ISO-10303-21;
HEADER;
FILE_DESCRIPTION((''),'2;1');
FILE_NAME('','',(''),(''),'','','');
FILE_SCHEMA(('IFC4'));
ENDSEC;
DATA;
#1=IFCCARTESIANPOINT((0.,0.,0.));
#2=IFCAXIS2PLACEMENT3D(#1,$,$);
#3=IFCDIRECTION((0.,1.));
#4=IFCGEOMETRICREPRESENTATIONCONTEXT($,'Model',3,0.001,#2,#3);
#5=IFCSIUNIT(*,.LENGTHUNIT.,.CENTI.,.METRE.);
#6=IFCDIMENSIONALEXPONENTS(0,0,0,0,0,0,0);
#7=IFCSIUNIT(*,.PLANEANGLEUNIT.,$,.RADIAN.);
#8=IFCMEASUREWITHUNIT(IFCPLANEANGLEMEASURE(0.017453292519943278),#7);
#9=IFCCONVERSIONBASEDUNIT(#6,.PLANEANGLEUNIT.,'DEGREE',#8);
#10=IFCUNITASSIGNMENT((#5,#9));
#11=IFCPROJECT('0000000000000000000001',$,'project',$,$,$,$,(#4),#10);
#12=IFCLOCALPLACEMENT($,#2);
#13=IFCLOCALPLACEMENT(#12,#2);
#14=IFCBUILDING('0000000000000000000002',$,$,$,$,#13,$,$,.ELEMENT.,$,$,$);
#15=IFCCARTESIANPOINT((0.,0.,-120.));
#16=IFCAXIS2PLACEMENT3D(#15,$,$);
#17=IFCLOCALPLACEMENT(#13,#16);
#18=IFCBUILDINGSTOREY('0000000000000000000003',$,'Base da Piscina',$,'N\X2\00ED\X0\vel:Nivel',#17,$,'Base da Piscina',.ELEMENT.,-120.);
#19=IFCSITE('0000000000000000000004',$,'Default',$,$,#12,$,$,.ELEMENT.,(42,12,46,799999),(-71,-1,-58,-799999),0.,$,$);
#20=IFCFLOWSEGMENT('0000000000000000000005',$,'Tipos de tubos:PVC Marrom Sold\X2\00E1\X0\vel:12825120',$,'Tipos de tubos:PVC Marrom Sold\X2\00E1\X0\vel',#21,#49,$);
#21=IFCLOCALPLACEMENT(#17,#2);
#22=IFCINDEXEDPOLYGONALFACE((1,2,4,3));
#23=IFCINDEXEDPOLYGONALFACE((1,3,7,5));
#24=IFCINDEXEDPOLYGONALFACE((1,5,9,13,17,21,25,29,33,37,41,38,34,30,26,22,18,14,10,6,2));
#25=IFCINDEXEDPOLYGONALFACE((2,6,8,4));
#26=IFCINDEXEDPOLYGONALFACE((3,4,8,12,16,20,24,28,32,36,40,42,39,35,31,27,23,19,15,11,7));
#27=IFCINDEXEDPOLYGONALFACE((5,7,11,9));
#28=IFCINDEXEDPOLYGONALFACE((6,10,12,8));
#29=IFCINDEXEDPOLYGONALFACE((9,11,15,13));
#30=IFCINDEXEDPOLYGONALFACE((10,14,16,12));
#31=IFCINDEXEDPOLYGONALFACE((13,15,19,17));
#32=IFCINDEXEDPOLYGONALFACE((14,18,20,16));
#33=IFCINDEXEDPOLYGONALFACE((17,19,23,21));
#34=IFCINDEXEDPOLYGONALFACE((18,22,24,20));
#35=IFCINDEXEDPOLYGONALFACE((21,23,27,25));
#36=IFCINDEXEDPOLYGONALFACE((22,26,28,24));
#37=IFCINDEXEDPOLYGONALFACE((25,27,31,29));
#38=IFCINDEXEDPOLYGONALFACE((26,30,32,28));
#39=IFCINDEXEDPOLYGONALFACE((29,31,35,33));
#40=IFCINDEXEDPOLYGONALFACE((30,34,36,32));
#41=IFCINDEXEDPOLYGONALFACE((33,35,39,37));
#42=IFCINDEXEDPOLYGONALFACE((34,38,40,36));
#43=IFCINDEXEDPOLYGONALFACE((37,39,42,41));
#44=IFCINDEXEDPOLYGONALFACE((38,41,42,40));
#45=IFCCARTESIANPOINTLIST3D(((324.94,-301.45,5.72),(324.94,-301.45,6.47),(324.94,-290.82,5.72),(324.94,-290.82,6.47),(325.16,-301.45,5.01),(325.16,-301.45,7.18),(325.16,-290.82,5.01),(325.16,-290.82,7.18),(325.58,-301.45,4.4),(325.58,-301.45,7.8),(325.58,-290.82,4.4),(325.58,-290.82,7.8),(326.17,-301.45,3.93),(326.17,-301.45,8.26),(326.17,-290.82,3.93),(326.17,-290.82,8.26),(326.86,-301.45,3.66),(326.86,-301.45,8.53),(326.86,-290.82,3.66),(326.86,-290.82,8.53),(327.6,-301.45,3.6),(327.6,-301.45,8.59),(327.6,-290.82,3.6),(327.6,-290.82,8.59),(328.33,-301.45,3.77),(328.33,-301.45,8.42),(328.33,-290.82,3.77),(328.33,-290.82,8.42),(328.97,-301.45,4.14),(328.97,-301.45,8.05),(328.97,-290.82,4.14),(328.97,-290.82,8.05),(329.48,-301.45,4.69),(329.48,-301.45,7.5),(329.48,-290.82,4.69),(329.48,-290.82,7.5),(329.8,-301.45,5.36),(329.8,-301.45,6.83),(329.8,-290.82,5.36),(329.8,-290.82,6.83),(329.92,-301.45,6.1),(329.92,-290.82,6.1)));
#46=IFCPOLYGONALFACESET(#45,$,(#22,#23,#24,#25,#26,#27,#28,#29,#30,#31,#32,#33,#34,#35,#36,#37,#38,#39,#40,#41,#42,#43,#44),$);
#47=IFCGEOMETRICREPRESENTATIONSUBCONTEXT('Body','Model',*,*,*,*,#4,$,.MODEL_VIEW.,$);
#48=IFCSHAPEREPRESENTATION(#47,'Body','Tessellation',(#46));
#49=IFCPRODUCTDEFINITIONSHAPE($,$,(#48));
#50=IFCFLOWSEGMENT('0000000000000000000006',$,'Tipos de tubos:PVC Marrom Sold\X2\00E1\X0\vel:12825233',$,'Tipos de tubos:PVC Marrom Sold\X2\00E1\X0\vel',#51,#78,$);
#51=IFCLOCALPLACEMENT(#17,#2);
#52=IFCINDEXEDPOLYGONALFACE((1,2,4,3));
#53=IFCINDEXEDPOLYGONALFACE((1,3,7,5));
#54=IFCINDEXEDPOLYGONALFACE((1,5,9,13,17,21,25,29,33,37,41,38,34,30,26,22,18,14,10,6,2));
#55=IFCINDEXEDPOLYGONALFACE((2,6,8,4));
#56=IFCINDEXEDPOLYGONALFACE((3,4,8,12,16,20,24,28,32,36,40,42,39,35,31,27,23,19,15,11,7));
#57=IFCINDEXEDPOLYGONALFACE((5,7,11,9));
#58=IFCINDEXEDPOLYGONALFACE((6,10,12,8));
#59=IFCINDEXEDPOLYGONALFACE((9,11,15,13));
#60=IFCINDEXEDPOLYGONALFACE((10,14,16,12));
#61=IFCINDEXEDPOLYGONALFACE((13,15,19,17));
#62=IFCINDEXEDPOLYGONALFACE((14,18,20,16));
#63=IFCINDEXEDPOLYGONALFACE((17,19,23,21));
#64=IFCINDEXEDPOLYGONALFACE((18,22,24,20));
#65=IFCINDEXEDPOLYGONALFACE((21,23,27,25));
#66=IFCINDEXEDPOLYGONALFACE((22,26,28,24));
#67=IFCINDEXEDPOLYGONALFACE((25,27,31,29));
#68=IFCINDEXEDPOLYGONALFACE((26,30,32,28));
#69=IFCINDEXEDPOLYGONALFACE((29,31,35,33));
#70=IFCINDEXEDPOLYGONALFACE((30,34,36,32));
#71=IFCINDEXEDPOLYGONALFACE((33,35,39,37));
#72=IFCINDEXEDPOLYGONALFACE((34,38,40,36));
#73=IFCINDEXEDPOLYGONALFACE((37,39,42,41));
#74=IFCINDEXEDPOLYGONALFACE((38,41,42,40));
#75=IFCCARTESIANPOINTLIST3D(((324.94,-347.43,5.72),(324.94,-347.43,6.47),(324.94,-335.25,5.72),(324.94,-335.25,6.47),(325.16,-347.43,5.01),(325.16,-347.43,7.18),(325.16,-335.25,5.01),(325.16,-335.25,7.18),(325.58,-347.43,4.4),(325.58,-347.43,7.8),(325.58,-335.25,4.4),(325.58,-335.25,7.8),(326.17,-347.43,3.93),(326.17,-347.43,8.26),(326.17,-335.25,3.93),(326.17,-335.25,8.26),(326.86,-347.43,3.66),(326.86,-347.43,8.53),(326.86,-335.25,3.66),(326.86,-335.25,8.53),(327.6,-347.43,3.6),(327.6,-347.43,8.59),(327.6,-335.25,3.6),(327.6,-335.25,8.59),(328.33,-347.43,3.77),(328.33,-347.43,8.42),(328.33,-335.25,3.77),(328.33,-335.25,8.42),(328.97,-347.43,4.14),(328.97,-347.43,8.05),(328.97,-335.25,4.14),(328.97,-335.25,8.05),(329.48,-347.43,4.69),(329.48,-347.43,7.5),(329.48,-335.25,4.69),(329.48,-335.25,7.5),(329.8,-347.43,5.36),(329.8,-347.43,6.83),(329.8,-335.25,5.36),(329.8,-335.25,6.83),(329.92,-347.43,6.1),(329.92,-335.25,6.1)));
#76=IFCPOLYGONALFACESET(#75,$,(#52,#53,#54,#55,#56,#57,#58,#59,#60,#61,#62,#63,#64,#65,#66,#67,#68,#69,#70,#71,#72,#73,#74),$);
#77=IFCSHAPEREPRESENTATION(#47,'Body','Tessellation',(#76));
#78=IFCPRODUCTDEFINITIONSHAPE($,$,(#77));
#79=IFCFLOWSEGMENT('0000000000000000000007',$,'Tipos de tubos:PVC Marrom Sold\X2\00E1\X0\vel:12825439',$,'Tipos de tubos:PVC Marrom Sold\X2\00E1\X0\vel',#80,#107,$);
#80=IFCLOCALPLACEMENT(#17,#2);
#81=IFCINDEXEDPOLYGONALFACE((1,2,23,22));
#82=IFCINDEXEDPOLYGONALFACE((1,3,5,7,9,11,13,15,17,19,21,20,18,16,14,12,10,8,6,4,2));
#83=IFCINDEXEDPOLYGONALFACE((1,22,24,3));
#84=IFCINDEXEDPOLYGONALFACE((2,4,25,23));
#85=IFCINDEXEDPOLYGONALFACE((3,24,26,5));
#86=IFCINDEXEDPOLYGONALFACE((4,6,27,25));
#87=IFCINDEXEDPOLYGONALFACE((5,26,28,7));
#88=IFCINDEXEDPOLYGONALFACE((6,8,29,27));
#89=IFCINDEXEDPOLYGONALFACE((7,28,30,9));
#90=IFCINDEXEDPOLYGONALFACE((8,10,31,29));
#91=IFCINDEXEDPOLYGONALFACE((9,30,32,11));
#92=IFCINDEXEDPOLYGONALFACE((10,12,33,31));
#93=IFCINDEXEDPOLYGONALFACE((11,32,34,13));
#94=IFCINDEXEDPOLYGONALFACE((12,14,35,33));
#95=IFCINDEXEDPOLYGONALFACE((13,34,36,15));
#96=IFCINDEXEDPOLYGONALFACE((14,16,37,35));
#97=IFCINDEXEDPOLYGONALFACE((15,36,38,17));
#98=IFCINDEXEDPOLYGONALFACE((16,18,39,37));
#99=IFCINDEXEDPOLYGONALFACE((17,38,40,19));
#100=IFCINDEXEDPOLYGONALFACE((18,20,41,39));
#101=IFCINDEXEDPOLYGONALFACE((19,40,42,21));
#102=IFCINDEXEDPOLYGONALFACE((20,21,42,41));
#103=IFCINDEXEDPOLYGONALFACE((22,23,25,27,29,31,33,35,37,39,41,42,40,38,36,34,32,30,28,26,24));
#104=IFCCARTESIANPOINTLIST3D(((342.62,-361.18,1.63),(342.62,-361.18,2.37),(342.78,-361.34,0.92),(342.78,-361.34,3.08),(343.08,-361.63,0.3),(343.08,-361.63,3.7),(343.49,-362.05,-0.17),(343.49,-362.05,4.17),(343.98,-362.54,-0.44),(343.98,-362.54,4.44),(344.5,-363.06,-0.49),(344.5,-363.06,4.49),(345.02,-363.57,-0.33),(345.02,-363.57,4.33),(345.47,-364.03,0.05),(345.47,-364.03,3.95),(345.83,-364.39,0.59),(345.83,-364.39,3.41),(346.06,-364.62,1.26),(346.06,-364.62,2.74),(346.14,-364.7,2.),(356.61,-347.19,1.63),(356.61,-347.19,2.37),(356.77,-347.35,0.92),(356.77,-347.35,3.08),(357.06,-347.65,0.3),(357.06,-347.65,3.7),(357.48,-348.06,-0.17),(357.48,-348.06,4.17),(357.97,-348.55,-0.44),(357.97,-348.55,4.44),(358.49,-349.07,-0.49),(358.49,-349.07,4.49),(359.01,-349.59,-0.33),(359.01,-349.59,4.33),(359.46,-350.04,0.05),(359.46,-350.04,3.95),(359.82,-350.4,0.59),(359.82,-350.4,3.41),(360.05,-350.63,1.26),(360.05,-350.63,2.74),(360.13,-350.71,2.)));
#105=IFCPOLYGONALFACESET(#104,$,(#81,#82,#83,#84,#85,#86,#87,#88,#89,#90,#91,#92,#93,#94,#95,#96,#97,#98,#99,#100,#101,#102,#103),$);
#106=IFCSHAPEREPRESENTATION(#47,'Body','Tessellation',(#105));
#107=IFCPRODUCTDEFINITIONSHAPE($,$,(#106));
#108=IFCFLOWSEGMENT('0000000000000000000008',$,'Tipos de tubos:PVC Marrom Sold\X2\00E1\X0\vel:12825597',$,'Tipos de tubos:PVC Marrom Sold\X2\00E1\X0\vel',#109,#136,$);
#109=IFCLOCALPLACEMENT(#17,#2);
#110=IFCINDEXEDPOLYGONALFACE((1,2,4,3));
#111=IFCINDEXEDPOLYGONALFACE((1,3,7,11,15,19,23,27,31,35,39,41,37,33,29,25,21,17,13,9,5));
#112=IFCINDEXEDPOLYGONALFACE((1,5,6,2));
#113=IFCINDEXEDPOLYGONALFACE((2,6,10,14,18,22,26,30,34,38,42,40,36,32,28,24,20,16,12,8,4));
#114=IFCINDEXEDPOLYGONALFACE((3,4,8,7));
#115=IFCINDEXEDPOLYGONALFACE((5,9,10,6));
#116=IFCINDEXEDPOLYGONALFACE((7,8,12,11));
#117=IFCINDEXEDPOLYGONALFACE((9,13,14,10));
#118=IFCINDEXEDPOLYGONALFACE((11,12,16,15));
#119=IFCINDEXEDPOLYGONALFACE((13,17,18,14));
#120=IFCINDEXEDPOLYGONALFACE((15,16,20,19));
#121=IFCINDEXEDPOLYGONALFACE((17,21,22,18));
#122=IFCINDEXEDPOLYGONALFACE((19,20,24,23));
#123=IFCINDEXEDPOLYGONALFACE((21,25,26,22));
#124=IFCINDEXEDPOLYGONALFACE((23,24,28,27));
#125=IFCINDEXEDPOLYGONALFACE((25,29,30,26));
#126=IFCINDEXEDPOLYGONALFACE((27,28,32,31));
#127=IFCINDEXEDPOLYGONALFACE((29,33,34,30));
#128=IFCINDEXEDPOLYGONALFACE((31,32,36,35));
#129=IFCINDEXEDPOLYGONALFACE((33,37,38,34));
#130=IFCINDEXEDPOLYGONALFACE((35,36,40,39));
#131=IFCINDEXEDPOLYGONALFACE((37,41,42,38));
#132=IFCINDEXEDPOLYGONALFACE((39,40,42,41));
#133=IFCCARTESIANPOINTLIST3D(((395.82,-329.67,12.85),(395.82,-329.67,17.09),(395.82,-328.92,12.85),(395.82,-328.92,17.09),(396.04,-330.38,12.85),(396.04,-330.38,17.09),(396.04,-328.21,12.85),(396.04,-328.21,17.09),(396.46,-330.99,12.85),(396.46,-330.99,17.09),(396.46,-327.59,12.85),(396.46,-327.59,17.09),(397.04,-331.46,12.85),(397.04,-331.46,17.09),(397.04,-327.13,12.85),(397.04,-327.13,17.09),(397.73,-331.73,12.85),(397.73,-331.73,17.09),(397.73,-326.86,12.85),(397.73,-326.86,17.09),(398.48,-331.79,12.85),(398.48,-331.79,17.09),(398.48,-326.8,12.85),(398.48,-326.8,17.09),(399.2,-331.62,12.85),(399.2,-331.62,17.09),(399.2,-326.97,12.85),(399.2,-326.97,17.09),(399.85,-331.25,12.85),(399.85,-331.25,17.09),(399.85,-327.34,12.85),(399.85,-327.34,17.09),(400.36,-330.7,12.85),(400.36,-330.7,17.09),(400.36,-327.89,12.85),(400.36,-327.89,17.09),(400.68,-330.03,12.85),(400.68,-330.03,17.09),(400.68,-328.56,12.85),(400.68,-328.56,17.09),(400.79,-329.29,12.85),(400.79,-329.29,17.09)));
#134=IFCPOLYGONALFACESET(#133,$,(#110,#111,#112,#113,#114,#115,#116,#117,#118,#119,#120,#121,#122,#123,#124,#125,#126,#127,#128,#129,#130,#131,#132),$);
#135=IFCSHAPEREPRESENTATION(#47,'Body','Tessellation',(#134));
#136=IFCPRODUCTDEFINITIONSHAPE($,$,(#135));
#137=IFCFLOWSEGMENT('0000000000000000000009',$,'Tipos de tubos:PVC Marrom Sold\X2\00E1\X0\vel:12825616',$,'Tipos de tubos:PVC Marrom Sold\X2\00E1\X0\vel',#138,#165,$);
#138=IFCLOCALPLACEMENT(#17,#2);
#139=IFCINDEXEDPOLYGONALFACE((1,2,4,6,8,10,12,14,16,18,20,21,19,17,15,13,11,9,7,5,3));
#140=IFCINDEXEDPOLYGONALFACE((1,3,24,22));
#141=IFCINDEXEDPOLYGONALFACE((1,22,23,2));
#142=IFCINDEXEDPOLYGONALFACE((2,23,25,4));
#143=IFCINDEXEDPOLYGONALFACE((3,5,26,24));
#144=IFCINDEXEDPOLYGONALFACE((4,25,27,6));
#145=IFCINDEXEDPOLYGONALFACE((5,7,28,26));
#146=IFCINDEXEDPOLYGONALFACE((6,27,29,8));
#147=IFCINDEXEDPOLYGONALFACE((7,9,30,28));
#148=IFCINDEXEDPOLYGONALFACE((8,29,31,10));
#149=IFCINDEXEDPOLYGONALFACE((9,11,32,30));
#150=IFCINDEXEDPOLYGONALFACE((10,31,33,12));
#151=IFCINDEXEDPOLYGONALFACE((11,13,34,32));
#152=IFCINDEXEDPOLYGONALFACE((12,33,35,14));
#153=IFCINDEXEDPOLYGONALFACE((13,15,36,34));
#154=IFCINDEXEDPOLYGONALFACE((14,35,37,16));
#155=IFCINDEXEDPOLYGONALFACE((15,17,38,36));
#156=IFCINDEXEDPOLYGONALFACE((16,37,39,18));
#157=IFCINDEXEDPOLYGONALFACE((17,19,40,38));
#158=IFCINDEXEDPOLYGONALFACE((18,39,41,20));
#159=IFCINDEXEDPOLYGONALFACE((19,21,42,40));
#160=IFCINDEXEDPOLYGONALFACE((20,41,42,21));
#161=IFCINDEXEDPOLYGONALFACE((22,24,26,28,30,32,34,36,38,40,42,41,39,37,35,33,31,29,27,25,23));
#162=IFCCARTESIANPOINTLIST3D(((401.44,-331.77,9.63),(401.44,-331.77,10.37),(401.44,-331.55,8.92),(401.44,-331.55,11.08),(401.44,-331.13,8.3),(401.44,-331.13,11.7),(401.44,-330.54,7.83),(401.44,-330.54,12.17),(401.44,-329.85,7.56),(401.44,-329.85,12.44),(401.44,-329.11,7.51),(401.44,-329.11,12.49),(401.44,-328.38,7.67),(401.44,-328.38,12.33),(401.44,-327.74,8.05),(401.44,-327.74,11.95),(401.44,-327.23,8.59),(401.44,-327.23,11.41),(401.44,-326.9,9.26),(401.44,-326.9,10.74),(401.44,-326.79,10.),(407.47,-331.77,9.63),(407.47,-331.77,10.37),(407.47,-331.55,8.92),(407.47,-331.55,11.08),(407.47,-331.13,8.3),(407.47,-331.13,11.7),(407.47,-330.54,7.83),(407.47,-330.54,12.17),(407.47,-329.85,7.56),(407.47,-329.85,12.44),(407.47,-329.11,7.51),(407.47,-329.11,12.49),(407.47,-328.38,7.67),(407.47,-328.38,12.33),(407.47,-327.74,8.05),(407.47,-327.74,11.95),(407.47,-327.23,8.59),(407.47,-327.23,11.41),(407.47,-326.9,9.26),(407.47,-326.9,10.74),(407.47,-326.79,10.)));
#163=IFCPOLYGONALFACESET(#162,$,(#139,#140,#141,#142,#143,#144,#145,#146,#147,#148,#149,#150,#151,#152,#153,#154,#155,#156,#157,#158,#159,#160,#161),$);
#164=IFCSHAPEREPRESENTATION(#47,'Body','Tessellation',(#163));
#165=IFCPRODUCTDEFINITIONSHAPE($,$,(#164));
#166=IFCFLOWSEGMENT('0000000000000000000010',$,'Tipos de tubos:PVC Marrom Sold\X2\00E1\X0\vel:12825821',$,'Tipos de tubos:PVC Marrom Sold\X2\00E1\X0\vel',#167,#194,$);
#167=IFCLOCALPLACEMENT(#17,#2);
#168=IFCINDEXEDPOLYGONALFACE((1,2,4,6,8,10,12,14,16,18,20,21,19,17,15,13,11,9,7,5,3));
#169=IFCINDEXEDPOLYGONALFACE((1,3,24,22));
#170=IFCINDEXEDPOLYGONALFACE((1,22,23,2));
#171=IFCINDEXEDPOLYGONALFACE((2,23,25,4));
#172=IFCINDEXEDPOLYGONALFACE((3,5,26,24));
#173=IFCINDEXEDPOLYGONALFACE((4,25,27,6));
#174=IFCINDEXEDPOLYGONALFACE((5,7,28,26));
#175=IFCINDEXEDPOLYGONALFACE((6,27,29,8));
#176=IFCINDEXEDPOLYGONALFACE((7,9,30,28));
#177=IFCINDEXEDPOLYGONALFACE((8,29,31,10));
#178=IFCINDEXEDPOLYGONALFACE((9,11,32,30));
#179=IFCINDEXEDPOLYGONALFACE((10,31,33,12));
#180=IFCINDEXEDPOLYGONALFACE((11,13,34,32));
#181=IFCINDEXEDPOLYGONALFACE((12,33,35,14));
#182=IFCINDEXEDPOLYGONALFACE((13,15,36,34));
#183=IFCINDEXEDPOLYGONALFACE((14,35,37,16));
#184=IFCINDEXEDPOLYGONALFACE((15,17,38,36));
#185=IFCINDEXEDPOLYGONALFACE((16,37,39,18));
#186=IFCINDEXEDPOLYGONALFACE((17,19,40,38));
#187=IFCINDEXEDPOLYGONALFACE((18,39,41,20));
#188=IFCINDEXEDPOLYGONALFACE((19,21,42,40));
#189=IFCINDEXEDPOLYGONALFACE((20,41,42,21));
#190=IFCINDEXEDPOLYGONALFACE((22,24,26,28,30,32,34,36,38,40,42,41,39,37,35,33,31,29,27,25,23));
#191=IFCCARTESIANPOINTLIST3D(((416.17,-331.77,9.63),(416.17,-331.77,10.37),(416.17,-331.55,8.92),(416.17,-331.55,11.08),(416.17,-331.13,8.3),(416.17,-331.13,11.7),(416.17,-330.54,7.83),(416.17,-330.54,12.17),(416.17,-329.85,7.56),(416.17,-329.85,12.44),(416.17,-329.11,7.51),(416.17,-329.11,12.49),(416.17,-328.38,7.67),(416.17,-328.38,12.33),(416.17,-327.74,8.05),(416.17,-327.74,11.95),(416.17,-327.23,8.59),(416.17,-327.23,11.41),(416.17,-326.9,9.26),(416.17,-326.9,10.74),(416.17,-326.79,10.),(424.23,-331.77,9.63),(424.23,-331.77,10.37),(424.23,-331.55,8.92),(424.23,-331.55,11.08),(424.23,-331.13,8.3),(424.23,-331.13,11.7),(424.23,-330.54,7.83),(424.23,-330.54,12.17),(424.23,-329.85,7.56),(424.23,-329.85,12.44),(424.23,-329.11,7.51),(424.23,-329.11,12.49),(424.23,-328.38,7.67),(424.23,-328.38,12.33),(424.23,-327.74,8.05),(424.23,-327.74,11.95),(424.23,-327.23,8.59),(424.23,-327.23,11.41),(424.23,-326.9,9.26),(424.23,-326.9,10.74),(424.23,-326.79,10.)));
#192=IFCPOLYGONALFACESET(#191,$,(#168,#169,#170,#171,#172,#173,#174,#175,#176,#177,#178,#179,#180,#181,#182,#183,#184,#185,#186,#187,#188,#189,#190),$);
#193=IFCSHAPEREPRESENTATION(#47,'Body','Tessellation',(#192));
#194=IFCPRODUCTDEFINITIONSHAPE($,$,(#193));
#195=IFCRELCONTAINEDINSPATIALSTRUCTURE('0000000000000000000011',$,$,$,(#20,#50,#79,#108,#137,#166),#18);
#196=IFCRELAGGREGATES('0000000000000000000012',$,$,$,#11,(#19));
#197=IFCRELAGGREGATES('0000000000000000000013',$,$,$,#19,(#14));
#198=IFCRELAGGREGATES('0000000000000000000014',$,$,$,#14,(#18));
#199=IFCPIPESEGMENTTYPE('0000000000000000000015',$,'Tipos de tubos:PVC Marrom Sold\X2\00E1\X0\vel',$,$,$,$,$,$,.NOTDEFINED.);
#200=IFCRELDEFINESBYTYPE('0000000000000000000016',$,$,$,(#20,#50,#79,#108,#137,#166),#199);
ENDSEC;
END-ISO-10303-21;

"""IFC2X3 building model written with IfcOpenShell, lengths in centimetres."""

from ifc_helpers import new_model, entity, si_unit, converted_unit, direction, frame, origin, origin_2d_with_axis, place, context, subcontext, project, spatial, circle, extrude, type_object, element, save


model = new_model("IFC2X3")

# Units and contexts
model_context = context("Model", 3, precision=0.001, world=origin(), true_north=direction((0.0, 1.0)))
body_context = subcontext(model_context, "Body", "Model", "MODEL_VIEW")
ifc_project = project(units=[si_unit("LENGTHUNIT", "METRE", prefix="CENTI"), converted_unit("PLANEANGLEUNIT", "DEGREE", entity("IfcPlaneAngleMeasure", 0.017453292519943278), si_unit("PLANEANGLEUNIT", "RADIAN"), dimensions=[0, 0, 0, 0, 0, 0, 0])], contexts=[model_context])

# Site, building, storey
site_placement = place(None, origin())
site = spatial("IfcSite", under=ifc_project, at=site_placement, Name="Default", CompositionType="ELEMENT", RefLatitude=(42, 12, 46, 799999), RefLongitude=(-71, -1, -58, -799999), RefElevation=0.0)
building_placement = place(site_placement, origin())
building = spatial("IfcBuilding", under=site, at=building_placement, CompositionType="ELEMENT")
storey_placement = place(building_placement, frame((0.0, 0.0, -120.0)))
storey = spatial("IfcBuildingStorey", under=building, at=storey_placement, Name="Base da Piscina", ObjectType="Nível:Nivel", LongName="Base da Piscina", CompositionType="ELEMENT", Elevation=-120.0)

# Flow segments
pipe_segment_type = type_object("IfcPipeSegmentType", Name="Tipos de tubos:PVC Marrom Soldável", PredefinedType="NOTDEFINED")
flow_segment_1_placement = place(storey_placement, origin())
element("IfcFlowSegment", 1, at=flow_segment_1_placement, inside=storey, type_object=pipe_segment_type, Name="Tipos de tubos:PVC Marrom Soldável:12825120", ObjectType="Tipos de tubos:PVC Marrom Soldável", context=body_context, shape_type="SweptSolid", body=[
    extrude(circle(Radius=2.5, at=origin_2d_with_axis()), frame((327.42, -301.45, 6.1), z_axis=(0.0, 1.0, 0.0), x_axis=(1.0, 0.0, 0.0)), (0.0, 0.0, 1.0), 10.63),
])
flow_segment_2_placement = place(storey_placement, origin())
element("IfcFlowSegment", 2, at=flow_segment_2_placement, inside=storey, type_object=pipe_segment_type, Name="Tipos de tubos:PVC Marrom Soldável:12825233", ObjectType="Tipos de tubos:PVC Marrom Soldável", context=body_context, shape_type="SweptSolid", body=[
    extrude(circle(Radius=2.5, at=origin_2d_with_axis()), frame((327.42, -347.43, 6.1), z_axis=(0.0, 1.0, 0.0), x_axis=(1.0, 0.0, 0.0)), (0.0, 0.0, 1.0), 12.18),
])
flow_segment_3_placement = place(storey_placement, origin())
element("IfcFlowSegment", 3, at=flow_segment_3_placement, inside=storey, type_object=pipe_segment_type, Name="Tipos de tubos:PVC Marrom Soldável:12825439", ObjectType="Tipos de tubos:PVC Marrom Soldável", context=body_context, shape_type="SweptSolid", body=[
    extrude(circle(Radius=2.5, at=origin_2d_with_axis()), frame((344.37, -362.93, 2.0), z_axis=(0.707107, 0.707107, 0.0), x_axis=(0.707107, -0.707107, 0.0)), (0.0, 0.0, 1.0), 19.78),
])
flow_segment_4_placement = place(storey_placement, origin())
element("IfcFlowSegment", 4, at=flow_segment_4_placement, inside=storey, type_object=pipe_segment_type, Name="Tipos de tubos:PVC Marrom Soldável:12825597", ObjectType="Tipos de tubos:PVC Marrom Soldável", context=body_context, shape_type="SweptSolid", body=[
    extrude(circle(Radius=2.5, at=origin_2d_with_axis()), frame((398.29, -329.29, 12.85)), (0.0, 0.0, 1.0), 4.24),
])
flow_segment_5_placement = place(storey_placement, origin())
element("IfcFlowSegment", 5, at=flow_segment_5_placement, inside=storey, type_object=pipe_segment_type, Name="Tipos de tubos:PVC Marrom Soldável:12825616", ObjectType="Tipos de tubos:PVC Marrom Soldável", context=body_context, shape_type="SweptSolid", body=[
    extrude(circle(Radius=2.5, at=origin_2d_with_axis()), frame((401.44, -329.29, 10.0), z_axis=(1.0, 0.0, 0.0), x_axis=(0.0, 1.0, 0.0)), (0.0, 0.0, 1.0), 6.03),
])
flow_segment_6_placement = place(storey_placement, origin())
element("IfcFlowSegment", 6, at=flow_segment_6_placement, inside=storey, type_object=pipe_segment_type, Name="Tipos de tubos:PVC Marrom Soldável:12825821", ObjectType="Tipos de tubos:PVC Marrom Soldável", context=body_context, shape_type="SweptSolid", body=[
    extrude(circle(Radius=2.5, at=origin_2d_with_axis()), frame((416.17, -329.29, 10.0), z_axis=(1.0, 0.0, 0.0), x_axis=(0.0, 1.0, 0.0)), (0.0, 0.0, 1.0), 8.06),
])

save(model, "model.ifc")
